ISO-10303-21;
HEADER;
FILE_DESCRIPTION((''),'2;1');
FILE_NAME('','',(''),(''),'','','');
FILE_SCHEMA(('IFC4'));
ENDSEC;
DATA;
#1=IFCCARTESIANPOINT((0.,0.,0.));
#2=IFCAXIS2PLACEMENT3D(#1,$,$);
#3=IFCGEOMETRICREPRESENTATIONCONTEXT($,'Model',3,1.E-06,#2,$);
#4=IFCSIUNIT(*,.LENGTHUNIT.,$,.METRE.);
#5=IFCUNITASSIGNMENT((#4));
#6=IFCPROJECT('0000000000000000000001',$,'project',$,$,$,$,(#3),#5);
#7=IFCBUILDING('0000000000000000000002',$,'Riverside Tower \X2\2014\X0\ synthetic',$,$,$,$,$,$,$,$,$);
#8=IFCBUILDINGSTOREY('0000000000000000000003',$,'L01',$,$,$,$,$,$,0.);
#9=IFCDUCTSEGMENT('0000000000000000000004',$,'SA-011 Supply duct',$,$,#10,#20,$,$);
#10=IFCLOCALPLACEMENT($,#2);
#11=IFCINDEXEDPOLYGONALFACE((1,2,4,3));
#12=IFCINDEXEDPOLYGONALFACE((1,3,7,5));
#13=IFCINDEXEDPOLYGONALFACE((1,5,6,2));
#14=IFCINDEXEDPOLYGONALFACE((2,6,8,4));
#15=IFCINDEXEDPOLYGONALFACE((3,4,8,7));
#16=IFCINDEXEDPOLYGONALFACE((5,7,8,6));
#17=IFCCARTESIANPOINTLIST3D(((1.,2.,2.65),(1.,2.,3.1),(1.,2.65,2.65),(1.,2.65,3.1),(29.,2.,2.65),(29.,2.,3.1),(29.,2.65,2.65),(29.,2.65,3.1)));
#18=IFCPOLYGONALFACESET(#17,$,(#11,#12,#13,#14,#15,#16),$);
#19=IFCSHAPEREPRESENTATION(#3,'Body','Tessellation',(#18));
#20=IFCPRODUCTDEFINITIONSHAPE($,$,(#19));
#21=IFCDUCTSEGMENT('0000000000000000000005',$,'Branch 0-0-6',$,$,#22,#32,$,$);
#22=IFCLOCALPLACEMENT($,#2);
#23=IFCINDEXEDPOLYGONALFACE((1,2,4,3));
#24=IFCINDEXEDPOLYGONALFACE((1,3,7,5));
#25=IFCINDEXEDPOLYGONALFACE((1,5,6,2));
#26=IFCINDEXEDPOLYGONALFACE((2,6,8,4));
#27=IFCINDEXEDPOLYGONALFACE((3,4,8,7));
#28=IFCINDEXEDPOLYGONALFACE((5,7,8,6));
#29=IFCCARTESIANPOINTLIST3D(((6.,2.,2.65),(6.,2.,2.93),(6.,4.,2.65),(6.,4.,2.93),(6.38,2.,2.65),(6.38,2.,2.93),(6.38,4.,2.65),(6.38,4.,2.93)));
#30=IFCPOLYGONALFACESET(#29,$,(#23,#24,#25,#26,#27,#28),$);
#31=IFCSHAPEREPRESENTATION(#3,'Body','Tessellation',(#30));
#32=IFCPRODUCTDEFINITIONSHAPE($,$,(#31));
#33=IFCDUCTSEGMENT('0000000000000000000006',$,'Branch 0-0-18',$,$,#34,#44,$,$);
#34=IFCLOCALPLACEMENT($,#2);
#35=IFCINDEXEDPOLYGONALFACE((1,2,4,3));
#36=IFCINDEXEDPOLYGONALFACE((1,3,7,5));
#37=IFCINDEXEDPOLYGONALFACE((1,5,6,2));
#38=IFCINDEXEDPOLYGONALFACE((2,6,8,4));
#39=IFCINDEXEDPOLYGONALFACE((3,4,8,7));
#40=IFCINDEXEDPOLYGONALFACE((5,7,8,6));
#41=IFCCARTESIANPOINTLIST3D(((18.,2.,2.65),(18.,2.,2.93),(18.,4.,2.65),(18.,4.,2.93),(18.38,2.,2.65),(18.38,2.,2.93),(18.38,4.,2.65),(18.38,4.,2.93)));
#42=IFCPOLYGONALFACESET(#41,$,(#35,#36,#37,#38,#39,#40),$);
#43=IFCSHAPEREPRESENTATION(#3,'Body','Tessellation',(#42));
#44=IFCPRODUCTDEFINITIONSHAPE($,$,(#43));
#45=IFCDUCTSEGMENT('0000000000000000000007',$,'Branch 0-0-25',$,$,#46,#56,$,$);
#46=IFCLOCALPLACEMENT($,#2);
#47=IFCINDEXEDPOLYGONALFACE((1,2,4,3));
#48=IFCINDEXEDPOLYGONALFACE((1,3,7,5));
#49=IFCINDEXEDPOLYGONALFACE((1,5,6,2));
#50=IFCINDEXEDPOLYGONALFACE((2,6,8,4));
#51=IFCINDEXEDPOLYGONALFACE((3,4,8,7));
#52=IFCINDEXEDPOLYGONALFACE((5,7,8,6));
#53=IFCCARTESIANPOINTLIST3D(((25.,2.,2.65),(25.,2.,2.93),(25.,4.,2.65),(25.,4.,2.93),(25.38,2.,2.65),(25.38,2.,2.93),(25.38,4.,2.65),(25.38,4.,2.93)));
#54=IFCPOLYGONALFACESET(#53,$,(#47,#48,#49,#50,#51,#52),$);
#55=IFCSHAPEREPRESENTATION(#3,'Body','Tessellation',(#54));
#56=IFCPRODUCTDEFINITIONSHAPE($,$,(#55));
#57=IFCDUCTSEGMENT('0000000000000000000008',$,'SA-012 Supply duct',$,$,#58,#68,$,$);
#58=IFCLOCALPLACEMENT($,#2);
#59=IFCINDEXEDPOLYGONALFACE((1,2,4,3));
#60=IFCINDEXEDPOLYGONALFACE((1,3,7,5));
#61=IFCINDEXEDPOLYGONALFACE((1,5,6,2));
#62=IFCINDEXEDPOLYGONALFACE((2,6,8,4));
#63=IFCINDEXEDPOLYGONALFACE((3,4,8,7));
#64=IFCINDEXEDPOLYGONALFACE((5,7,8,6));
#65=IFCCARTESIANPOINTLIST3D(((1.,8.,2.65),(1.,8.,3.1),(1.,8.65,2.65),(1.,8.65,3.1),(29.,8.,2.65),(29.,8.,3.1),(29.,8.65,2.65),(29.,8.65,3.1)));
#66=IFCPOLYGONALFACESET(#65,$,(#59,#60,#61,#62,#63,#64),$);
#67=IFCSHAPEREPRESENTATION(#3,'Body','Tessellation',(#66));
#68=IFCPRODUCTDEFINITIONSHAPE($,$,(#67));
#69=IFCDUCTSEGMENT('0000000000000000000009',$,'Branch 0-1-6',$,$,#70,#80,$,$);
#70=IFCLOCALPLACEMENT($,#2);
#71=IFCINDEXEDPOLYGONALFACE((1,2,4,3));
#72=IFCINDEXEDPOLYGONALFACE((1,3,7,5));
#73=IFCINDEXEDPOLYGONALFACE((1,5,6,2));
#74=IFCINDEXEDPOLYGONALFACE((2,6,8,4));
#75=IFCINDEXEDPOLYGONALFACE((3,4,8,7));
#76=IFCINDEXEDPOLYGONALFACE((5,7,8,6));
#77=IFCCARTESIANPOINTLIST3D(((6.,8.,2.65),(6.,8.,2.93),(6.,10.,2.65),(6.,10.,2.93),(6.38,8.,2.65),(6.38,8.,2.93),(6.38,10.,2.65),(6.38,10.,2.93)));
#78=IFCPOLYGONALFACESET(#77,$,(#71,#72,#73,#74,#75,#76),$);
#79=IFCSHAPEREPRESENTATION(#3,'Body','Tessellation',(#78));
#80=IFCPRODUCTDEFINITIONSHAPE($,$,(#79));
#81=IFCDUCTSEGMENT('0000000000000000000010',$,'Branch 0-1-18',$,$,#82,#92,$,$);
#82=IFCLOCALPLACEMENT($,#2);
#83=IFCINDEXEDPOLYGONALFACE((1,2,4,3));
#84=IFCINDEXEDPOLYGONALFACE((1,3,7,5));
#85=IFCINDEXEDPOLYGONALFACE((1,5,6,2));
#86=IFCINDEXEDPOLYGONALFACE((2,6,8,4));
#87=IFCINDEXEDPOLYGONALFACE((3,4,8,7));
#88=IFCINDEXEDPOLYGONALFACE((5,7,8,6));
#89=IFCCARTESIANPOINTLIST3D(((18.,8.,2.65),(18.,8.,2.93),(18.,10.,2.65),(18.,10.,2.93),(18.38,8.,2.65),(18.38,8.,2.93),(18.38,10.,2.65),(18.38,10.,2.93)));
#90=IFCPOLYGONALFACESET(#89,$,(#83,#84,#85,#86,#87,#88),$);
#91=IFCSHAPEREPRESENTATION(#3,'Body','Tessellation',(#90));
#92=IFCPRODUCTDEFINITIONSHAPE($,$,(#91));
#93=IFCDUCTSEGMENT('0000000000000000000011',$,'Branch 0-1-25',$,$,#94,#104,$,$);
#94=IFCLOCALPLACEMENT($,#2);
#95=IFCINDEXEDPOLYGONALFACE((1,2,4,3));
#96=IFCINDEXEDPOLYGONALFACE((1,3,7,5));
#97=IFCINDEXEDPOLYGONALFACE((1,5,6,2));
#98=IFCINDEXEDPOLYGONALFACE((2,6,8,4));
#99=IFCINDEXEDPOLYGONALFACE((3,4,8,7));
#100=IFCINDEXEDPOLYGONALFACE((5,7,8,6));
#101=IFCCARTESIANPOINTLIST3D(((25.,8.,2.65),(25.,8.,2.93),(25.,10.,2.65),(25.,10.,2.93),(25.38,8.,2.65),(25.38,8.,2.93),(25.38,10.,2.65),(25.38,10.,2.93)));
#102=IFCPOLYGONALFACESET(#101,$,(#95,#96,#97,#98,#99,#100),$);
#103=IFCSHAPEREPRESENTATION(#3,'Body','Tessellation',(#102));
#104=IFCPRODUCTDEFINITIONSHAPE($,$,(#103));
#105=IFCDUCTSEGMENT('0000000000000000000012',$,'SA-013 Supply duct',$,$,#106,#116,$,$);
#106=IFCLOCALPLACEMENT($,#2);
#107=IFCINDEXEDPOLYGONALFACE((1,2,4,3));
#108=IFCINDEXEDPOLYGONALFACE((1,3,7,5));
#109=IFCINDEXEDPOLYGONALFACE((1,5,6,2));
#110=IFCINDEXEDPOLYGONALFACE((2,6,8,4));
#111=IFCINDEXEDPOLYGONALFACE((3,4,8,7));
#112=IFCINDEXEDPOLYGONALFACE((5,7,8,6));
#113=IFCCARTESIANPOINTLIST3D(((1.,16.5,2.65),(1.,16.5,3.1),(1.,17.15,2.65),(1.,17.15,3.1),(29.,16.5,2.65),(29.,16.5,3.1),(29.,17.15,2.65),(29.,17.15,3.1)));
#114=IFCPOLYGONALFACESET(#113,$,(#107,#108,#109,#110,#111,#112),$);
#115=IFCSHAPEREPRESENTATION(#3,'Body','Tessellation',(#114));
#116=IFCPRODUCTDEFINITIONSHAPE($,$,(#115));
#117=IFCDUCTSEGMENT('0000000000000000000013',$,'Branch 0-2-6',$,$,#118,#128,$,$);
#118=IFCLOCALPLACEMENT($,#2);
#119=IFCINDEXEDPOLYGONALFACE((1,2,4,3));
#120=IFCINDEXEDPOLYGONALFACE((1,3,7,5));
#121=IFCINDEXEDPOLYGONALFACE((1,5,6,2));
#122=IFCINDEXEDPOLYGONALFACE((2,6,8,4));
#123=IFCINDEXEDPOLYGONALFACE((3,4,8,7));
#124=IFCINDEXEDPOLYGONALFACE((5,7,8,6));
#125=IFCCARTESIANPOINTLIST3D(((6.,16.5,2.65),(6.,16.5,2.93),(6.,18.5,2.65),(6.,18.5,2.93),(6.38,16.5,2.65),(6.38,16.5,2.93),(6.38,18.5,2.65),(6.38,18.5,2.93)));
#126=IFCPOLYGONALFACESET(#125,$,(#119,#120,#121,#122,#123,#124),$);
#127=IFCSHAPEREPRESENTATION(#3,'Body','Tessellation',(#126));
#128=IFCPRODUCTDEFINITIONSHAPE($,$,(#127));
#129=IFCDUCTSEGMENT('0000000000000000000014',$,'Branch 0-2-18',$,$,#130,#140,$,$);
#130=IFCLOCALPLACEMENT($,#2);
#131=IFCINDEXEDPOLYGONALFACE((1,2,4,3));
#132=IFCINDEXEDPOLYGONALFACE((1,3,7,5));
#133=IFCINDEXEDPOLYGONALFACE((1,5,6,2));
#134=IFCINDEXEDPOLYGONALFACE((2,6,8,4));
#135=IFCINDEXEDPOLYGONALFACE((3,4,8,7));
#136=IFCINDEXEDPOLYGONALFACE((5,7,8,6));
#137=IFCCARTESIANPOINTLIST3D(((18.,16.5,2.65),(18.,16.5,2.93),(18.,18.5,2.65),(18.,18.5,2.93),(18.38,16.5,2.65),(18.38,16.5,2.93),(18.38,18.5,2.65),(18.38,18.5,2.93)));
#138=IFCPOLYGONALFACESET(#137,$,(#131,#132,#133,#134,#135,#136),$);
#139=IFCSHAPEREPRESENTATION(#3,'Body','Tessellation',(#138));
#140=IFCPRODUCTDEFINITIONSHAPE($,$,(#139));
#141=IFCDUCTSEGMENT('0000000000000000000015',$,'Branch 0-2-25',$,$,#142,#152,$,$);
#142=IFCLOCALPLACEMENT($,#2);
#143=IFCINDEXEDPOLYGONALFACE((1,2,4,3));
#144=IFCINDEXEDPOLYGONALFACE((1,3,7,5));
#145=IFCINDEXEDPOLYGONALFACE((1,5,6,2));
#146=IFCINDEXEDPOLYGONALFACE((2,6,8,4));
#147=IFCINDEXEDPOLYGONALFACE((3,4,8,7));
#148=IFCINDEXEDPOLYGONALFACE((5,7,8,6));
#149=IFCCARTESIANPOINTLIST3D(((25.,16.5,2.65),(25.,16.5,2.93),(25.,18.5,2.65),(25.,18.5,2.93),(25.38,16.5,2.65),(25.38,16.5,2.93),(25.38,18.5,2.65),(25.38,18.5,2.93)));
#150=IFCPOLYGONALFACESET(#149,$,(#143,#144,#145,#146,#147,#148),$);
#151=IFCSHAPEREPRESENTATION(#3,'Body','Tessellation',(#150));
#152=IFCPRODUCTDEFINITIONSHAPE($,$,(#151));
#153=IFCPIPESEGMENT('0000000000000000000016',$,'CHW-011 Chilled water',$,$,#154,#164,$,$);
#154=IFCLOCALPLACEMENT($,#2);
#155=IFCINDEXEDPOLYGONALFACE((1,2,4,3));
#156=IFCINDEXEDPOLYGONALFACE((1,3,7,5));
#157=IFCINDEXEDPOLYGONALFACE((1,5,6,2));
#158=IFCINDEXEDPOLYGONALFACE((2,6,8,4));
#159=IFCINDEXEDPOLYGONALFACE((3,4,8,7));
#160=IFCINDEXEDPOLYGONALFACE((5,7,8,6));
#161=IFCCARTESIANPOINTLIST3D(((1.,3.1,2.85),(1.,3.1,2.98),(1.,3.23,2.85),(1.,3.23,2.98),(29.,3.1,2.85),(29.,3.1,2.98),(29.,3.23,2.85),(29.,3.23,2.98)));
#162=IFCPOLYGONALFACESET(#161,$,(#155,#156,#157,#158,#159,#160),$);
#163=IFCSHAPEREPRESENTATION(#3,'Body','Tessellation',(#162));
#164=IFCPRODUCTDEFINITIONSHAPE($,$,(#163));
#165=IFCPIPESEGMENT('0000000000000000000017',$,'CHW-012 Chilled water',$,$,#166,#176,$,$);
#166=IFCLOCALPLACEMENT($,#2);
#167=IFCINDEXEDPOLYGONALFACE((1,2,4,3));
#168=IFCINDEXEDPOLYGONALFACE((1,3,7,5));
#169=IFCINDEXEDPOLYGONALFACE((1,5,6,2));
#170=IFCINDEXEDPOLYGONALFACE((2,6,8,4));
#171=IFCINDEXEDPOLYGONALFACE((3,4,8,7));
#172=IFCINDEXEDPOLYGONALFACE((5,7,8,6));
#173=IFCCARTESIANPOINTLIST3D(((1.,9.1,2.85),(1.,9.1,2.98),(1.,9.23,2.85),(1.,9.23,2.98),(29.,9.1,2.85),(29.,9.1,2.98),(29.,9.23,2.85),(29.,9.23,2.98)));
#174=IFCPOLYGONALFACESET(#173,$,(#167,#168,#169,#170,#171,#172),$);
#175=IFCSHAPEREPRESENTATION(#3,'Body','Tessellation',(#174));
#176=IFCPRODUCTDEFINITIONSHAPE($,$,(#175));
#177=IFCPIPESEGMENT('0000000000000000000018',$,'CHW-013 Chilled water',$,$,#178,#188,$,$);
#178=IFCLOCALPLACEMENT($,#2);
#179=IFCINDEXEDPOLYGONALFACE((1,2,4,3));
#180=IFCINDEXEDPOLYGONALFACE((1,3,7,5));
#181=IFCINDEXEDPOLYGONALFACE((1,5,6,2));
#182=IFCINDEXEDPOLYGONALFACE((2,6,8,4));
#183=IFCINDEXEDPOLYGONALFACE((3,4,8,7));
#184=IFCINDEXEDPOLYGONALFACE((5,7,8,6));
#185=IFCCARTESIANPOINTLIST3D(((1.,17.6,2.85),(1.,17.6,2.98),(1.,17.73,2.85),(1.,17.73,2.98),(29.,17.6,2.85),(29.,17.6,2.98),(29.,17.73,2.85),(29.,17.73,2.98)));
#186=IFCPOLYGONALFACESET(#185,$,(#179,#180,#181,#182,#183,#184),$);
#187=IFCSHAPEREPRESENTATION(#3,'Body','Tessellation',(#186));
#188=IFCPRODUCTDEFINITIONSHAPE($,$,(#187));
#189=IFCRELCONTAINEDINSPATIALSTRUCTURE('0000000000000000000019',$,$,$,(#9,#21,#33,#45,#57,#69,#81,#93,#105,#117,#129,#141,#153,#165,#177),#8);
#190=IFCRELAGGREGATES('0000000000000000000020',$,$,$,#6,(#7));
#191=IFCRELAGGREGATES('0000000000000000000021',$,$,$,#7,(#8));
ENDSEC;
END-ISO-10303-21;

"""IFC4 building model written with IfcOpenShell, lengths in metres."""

from ifc_helpers import new_model, si_unit, frame, origin, place, context, project, spatial, rectangle, extrude, element, save


model = new_model("IFC4")

# Units and contexts
model_context = context("Model", 3, precision=1e-06, world=origin())
ifc_project = project(units=[si_unit("LENGTHUNIT", "METRE")], contexts=[model_context])

# Building, storey
building = spatial("IfcBuilding", under=ifc_project, Name="Riverside Tower — synthetic")
storey = spatial("IfcBuildingStorey", under=building, Name="L01", Elevation=0.0)

# Duct segments
duct_segment_1_placement = place(None, frame((15.0, 2.325, 2.65)))
element("IfcDuctSegment", 1, at=duct_segment_1_placement, inside=storey, Name="SA-011 Supply duct", context=model_context, shape_type="SweptSolid", body=[
    extrude(rectangle(XDim=28.0, YDim=0.65), origin(), (0.0, 0.0, 1.0), 0.45),
])
for number, where, name in (
    (2, (6.19, 3.0, 2.65), "Branch 0-0-6"),
    (3, (18.19, 3.0, 2.65), "Branch 0-0-18"),
    (4, (25.19, 3.0, 2.65), "Branch 0-0-25"),
):
    element("IfcDuctSegment", number, at=place(None, frame(where)), inside=storey, Name=name, context=model_context, shape_type="SweptSolid", body=[
        extrude(rectangle(XDim=0.38, YDim=2.0), origin(), (0.0, 0.0, 1.0), 0.28),
    ])
duct_segment_2_placement = place(None, frame((15.0, 8.325, 2.65)))
element("IfcDuctSegment", 5, at=duct_segment_2_placement, inside=storey, Name="SA-012 Supply duct", context=model_context, shape_type="SweptSolid", body=[
    extrude(rectangle(XDim=28.0, YDim=0.65), origin(), (0.0, 0.0, 1.0), 0.45),
])
for number, where, name in (
    (6, (6.19, 9.0, 2.65), "Branch 0-1-6"),
    (7, (18.19, 9.0, 2.65), "Branch 0-1-18"),
    (8, (25.19, 9.0, 2.65), "Branch 0-1-25"),
):
    element("IfcDuctSegment", number, at=place(None, frame(where)), inside=storey, Name=name, context=model_context, shape_type="SweptSolid", body=[
        extrude(rectangle(XDim=0.38, YDim=2.0), origin(), (0.0, 0.0, 1.0), 0.28),
    ])
duct_segment_3_placement = place(None, frame((15.0, 16.825, 2.65)))
element("IfcDuctSegment", 9, at=duct_segment_3_placement, inside=storey, Name="SA-013 Supply duct", context=model_context, shape_type="SweptSolid", body=[
    extrude(rectangle(XDim=28.0, YDim=0.65), origin(), (0.0, 0.0, 1.0), 0.45),
])
for number, where, name in (
    (10, (6.19, 17.5, 2.65), "Branch 0-2-6"),
    (11, (18.19, 17.5, 2.65), "Branch 0-2-18"),
    (12, (25.19, 17.5, 2.65), "Branch 0-2-25"),
):
    element("IfcDuctSegment", number, at=place(None, frame(where)), inside=storey, Name=name, context=model_context, shape_type="SweptSolid", body=[
        extrude(rectangle(XDim=0.38, YDim=2.0), origin(), (0.0, 0.0, 1.0), 0.28),
    ])

# Pipe segments
for number, where, name in (
    (13, (15.0, 3.165, 2.85), "CHW-011 Chilled water"),
    (14, (15.0, 9.165, 2.85), "CHW-012 Chilled water"),
    (15, (15.0, 17.665, 2.85), "CHW-013 Chilled water"),
):
    element("IfcPipeSegment", number, at=place(None, frame(where)), inside=storey, Name=name, context=model_context, shape_type="SweptSolid", body=[
        extrude(rectangle(XDim=28.0, YDim=0.13), origin(), (0.0, 0.0, 1.0), 0.13),
    ])

save(model, "model.ifc")
